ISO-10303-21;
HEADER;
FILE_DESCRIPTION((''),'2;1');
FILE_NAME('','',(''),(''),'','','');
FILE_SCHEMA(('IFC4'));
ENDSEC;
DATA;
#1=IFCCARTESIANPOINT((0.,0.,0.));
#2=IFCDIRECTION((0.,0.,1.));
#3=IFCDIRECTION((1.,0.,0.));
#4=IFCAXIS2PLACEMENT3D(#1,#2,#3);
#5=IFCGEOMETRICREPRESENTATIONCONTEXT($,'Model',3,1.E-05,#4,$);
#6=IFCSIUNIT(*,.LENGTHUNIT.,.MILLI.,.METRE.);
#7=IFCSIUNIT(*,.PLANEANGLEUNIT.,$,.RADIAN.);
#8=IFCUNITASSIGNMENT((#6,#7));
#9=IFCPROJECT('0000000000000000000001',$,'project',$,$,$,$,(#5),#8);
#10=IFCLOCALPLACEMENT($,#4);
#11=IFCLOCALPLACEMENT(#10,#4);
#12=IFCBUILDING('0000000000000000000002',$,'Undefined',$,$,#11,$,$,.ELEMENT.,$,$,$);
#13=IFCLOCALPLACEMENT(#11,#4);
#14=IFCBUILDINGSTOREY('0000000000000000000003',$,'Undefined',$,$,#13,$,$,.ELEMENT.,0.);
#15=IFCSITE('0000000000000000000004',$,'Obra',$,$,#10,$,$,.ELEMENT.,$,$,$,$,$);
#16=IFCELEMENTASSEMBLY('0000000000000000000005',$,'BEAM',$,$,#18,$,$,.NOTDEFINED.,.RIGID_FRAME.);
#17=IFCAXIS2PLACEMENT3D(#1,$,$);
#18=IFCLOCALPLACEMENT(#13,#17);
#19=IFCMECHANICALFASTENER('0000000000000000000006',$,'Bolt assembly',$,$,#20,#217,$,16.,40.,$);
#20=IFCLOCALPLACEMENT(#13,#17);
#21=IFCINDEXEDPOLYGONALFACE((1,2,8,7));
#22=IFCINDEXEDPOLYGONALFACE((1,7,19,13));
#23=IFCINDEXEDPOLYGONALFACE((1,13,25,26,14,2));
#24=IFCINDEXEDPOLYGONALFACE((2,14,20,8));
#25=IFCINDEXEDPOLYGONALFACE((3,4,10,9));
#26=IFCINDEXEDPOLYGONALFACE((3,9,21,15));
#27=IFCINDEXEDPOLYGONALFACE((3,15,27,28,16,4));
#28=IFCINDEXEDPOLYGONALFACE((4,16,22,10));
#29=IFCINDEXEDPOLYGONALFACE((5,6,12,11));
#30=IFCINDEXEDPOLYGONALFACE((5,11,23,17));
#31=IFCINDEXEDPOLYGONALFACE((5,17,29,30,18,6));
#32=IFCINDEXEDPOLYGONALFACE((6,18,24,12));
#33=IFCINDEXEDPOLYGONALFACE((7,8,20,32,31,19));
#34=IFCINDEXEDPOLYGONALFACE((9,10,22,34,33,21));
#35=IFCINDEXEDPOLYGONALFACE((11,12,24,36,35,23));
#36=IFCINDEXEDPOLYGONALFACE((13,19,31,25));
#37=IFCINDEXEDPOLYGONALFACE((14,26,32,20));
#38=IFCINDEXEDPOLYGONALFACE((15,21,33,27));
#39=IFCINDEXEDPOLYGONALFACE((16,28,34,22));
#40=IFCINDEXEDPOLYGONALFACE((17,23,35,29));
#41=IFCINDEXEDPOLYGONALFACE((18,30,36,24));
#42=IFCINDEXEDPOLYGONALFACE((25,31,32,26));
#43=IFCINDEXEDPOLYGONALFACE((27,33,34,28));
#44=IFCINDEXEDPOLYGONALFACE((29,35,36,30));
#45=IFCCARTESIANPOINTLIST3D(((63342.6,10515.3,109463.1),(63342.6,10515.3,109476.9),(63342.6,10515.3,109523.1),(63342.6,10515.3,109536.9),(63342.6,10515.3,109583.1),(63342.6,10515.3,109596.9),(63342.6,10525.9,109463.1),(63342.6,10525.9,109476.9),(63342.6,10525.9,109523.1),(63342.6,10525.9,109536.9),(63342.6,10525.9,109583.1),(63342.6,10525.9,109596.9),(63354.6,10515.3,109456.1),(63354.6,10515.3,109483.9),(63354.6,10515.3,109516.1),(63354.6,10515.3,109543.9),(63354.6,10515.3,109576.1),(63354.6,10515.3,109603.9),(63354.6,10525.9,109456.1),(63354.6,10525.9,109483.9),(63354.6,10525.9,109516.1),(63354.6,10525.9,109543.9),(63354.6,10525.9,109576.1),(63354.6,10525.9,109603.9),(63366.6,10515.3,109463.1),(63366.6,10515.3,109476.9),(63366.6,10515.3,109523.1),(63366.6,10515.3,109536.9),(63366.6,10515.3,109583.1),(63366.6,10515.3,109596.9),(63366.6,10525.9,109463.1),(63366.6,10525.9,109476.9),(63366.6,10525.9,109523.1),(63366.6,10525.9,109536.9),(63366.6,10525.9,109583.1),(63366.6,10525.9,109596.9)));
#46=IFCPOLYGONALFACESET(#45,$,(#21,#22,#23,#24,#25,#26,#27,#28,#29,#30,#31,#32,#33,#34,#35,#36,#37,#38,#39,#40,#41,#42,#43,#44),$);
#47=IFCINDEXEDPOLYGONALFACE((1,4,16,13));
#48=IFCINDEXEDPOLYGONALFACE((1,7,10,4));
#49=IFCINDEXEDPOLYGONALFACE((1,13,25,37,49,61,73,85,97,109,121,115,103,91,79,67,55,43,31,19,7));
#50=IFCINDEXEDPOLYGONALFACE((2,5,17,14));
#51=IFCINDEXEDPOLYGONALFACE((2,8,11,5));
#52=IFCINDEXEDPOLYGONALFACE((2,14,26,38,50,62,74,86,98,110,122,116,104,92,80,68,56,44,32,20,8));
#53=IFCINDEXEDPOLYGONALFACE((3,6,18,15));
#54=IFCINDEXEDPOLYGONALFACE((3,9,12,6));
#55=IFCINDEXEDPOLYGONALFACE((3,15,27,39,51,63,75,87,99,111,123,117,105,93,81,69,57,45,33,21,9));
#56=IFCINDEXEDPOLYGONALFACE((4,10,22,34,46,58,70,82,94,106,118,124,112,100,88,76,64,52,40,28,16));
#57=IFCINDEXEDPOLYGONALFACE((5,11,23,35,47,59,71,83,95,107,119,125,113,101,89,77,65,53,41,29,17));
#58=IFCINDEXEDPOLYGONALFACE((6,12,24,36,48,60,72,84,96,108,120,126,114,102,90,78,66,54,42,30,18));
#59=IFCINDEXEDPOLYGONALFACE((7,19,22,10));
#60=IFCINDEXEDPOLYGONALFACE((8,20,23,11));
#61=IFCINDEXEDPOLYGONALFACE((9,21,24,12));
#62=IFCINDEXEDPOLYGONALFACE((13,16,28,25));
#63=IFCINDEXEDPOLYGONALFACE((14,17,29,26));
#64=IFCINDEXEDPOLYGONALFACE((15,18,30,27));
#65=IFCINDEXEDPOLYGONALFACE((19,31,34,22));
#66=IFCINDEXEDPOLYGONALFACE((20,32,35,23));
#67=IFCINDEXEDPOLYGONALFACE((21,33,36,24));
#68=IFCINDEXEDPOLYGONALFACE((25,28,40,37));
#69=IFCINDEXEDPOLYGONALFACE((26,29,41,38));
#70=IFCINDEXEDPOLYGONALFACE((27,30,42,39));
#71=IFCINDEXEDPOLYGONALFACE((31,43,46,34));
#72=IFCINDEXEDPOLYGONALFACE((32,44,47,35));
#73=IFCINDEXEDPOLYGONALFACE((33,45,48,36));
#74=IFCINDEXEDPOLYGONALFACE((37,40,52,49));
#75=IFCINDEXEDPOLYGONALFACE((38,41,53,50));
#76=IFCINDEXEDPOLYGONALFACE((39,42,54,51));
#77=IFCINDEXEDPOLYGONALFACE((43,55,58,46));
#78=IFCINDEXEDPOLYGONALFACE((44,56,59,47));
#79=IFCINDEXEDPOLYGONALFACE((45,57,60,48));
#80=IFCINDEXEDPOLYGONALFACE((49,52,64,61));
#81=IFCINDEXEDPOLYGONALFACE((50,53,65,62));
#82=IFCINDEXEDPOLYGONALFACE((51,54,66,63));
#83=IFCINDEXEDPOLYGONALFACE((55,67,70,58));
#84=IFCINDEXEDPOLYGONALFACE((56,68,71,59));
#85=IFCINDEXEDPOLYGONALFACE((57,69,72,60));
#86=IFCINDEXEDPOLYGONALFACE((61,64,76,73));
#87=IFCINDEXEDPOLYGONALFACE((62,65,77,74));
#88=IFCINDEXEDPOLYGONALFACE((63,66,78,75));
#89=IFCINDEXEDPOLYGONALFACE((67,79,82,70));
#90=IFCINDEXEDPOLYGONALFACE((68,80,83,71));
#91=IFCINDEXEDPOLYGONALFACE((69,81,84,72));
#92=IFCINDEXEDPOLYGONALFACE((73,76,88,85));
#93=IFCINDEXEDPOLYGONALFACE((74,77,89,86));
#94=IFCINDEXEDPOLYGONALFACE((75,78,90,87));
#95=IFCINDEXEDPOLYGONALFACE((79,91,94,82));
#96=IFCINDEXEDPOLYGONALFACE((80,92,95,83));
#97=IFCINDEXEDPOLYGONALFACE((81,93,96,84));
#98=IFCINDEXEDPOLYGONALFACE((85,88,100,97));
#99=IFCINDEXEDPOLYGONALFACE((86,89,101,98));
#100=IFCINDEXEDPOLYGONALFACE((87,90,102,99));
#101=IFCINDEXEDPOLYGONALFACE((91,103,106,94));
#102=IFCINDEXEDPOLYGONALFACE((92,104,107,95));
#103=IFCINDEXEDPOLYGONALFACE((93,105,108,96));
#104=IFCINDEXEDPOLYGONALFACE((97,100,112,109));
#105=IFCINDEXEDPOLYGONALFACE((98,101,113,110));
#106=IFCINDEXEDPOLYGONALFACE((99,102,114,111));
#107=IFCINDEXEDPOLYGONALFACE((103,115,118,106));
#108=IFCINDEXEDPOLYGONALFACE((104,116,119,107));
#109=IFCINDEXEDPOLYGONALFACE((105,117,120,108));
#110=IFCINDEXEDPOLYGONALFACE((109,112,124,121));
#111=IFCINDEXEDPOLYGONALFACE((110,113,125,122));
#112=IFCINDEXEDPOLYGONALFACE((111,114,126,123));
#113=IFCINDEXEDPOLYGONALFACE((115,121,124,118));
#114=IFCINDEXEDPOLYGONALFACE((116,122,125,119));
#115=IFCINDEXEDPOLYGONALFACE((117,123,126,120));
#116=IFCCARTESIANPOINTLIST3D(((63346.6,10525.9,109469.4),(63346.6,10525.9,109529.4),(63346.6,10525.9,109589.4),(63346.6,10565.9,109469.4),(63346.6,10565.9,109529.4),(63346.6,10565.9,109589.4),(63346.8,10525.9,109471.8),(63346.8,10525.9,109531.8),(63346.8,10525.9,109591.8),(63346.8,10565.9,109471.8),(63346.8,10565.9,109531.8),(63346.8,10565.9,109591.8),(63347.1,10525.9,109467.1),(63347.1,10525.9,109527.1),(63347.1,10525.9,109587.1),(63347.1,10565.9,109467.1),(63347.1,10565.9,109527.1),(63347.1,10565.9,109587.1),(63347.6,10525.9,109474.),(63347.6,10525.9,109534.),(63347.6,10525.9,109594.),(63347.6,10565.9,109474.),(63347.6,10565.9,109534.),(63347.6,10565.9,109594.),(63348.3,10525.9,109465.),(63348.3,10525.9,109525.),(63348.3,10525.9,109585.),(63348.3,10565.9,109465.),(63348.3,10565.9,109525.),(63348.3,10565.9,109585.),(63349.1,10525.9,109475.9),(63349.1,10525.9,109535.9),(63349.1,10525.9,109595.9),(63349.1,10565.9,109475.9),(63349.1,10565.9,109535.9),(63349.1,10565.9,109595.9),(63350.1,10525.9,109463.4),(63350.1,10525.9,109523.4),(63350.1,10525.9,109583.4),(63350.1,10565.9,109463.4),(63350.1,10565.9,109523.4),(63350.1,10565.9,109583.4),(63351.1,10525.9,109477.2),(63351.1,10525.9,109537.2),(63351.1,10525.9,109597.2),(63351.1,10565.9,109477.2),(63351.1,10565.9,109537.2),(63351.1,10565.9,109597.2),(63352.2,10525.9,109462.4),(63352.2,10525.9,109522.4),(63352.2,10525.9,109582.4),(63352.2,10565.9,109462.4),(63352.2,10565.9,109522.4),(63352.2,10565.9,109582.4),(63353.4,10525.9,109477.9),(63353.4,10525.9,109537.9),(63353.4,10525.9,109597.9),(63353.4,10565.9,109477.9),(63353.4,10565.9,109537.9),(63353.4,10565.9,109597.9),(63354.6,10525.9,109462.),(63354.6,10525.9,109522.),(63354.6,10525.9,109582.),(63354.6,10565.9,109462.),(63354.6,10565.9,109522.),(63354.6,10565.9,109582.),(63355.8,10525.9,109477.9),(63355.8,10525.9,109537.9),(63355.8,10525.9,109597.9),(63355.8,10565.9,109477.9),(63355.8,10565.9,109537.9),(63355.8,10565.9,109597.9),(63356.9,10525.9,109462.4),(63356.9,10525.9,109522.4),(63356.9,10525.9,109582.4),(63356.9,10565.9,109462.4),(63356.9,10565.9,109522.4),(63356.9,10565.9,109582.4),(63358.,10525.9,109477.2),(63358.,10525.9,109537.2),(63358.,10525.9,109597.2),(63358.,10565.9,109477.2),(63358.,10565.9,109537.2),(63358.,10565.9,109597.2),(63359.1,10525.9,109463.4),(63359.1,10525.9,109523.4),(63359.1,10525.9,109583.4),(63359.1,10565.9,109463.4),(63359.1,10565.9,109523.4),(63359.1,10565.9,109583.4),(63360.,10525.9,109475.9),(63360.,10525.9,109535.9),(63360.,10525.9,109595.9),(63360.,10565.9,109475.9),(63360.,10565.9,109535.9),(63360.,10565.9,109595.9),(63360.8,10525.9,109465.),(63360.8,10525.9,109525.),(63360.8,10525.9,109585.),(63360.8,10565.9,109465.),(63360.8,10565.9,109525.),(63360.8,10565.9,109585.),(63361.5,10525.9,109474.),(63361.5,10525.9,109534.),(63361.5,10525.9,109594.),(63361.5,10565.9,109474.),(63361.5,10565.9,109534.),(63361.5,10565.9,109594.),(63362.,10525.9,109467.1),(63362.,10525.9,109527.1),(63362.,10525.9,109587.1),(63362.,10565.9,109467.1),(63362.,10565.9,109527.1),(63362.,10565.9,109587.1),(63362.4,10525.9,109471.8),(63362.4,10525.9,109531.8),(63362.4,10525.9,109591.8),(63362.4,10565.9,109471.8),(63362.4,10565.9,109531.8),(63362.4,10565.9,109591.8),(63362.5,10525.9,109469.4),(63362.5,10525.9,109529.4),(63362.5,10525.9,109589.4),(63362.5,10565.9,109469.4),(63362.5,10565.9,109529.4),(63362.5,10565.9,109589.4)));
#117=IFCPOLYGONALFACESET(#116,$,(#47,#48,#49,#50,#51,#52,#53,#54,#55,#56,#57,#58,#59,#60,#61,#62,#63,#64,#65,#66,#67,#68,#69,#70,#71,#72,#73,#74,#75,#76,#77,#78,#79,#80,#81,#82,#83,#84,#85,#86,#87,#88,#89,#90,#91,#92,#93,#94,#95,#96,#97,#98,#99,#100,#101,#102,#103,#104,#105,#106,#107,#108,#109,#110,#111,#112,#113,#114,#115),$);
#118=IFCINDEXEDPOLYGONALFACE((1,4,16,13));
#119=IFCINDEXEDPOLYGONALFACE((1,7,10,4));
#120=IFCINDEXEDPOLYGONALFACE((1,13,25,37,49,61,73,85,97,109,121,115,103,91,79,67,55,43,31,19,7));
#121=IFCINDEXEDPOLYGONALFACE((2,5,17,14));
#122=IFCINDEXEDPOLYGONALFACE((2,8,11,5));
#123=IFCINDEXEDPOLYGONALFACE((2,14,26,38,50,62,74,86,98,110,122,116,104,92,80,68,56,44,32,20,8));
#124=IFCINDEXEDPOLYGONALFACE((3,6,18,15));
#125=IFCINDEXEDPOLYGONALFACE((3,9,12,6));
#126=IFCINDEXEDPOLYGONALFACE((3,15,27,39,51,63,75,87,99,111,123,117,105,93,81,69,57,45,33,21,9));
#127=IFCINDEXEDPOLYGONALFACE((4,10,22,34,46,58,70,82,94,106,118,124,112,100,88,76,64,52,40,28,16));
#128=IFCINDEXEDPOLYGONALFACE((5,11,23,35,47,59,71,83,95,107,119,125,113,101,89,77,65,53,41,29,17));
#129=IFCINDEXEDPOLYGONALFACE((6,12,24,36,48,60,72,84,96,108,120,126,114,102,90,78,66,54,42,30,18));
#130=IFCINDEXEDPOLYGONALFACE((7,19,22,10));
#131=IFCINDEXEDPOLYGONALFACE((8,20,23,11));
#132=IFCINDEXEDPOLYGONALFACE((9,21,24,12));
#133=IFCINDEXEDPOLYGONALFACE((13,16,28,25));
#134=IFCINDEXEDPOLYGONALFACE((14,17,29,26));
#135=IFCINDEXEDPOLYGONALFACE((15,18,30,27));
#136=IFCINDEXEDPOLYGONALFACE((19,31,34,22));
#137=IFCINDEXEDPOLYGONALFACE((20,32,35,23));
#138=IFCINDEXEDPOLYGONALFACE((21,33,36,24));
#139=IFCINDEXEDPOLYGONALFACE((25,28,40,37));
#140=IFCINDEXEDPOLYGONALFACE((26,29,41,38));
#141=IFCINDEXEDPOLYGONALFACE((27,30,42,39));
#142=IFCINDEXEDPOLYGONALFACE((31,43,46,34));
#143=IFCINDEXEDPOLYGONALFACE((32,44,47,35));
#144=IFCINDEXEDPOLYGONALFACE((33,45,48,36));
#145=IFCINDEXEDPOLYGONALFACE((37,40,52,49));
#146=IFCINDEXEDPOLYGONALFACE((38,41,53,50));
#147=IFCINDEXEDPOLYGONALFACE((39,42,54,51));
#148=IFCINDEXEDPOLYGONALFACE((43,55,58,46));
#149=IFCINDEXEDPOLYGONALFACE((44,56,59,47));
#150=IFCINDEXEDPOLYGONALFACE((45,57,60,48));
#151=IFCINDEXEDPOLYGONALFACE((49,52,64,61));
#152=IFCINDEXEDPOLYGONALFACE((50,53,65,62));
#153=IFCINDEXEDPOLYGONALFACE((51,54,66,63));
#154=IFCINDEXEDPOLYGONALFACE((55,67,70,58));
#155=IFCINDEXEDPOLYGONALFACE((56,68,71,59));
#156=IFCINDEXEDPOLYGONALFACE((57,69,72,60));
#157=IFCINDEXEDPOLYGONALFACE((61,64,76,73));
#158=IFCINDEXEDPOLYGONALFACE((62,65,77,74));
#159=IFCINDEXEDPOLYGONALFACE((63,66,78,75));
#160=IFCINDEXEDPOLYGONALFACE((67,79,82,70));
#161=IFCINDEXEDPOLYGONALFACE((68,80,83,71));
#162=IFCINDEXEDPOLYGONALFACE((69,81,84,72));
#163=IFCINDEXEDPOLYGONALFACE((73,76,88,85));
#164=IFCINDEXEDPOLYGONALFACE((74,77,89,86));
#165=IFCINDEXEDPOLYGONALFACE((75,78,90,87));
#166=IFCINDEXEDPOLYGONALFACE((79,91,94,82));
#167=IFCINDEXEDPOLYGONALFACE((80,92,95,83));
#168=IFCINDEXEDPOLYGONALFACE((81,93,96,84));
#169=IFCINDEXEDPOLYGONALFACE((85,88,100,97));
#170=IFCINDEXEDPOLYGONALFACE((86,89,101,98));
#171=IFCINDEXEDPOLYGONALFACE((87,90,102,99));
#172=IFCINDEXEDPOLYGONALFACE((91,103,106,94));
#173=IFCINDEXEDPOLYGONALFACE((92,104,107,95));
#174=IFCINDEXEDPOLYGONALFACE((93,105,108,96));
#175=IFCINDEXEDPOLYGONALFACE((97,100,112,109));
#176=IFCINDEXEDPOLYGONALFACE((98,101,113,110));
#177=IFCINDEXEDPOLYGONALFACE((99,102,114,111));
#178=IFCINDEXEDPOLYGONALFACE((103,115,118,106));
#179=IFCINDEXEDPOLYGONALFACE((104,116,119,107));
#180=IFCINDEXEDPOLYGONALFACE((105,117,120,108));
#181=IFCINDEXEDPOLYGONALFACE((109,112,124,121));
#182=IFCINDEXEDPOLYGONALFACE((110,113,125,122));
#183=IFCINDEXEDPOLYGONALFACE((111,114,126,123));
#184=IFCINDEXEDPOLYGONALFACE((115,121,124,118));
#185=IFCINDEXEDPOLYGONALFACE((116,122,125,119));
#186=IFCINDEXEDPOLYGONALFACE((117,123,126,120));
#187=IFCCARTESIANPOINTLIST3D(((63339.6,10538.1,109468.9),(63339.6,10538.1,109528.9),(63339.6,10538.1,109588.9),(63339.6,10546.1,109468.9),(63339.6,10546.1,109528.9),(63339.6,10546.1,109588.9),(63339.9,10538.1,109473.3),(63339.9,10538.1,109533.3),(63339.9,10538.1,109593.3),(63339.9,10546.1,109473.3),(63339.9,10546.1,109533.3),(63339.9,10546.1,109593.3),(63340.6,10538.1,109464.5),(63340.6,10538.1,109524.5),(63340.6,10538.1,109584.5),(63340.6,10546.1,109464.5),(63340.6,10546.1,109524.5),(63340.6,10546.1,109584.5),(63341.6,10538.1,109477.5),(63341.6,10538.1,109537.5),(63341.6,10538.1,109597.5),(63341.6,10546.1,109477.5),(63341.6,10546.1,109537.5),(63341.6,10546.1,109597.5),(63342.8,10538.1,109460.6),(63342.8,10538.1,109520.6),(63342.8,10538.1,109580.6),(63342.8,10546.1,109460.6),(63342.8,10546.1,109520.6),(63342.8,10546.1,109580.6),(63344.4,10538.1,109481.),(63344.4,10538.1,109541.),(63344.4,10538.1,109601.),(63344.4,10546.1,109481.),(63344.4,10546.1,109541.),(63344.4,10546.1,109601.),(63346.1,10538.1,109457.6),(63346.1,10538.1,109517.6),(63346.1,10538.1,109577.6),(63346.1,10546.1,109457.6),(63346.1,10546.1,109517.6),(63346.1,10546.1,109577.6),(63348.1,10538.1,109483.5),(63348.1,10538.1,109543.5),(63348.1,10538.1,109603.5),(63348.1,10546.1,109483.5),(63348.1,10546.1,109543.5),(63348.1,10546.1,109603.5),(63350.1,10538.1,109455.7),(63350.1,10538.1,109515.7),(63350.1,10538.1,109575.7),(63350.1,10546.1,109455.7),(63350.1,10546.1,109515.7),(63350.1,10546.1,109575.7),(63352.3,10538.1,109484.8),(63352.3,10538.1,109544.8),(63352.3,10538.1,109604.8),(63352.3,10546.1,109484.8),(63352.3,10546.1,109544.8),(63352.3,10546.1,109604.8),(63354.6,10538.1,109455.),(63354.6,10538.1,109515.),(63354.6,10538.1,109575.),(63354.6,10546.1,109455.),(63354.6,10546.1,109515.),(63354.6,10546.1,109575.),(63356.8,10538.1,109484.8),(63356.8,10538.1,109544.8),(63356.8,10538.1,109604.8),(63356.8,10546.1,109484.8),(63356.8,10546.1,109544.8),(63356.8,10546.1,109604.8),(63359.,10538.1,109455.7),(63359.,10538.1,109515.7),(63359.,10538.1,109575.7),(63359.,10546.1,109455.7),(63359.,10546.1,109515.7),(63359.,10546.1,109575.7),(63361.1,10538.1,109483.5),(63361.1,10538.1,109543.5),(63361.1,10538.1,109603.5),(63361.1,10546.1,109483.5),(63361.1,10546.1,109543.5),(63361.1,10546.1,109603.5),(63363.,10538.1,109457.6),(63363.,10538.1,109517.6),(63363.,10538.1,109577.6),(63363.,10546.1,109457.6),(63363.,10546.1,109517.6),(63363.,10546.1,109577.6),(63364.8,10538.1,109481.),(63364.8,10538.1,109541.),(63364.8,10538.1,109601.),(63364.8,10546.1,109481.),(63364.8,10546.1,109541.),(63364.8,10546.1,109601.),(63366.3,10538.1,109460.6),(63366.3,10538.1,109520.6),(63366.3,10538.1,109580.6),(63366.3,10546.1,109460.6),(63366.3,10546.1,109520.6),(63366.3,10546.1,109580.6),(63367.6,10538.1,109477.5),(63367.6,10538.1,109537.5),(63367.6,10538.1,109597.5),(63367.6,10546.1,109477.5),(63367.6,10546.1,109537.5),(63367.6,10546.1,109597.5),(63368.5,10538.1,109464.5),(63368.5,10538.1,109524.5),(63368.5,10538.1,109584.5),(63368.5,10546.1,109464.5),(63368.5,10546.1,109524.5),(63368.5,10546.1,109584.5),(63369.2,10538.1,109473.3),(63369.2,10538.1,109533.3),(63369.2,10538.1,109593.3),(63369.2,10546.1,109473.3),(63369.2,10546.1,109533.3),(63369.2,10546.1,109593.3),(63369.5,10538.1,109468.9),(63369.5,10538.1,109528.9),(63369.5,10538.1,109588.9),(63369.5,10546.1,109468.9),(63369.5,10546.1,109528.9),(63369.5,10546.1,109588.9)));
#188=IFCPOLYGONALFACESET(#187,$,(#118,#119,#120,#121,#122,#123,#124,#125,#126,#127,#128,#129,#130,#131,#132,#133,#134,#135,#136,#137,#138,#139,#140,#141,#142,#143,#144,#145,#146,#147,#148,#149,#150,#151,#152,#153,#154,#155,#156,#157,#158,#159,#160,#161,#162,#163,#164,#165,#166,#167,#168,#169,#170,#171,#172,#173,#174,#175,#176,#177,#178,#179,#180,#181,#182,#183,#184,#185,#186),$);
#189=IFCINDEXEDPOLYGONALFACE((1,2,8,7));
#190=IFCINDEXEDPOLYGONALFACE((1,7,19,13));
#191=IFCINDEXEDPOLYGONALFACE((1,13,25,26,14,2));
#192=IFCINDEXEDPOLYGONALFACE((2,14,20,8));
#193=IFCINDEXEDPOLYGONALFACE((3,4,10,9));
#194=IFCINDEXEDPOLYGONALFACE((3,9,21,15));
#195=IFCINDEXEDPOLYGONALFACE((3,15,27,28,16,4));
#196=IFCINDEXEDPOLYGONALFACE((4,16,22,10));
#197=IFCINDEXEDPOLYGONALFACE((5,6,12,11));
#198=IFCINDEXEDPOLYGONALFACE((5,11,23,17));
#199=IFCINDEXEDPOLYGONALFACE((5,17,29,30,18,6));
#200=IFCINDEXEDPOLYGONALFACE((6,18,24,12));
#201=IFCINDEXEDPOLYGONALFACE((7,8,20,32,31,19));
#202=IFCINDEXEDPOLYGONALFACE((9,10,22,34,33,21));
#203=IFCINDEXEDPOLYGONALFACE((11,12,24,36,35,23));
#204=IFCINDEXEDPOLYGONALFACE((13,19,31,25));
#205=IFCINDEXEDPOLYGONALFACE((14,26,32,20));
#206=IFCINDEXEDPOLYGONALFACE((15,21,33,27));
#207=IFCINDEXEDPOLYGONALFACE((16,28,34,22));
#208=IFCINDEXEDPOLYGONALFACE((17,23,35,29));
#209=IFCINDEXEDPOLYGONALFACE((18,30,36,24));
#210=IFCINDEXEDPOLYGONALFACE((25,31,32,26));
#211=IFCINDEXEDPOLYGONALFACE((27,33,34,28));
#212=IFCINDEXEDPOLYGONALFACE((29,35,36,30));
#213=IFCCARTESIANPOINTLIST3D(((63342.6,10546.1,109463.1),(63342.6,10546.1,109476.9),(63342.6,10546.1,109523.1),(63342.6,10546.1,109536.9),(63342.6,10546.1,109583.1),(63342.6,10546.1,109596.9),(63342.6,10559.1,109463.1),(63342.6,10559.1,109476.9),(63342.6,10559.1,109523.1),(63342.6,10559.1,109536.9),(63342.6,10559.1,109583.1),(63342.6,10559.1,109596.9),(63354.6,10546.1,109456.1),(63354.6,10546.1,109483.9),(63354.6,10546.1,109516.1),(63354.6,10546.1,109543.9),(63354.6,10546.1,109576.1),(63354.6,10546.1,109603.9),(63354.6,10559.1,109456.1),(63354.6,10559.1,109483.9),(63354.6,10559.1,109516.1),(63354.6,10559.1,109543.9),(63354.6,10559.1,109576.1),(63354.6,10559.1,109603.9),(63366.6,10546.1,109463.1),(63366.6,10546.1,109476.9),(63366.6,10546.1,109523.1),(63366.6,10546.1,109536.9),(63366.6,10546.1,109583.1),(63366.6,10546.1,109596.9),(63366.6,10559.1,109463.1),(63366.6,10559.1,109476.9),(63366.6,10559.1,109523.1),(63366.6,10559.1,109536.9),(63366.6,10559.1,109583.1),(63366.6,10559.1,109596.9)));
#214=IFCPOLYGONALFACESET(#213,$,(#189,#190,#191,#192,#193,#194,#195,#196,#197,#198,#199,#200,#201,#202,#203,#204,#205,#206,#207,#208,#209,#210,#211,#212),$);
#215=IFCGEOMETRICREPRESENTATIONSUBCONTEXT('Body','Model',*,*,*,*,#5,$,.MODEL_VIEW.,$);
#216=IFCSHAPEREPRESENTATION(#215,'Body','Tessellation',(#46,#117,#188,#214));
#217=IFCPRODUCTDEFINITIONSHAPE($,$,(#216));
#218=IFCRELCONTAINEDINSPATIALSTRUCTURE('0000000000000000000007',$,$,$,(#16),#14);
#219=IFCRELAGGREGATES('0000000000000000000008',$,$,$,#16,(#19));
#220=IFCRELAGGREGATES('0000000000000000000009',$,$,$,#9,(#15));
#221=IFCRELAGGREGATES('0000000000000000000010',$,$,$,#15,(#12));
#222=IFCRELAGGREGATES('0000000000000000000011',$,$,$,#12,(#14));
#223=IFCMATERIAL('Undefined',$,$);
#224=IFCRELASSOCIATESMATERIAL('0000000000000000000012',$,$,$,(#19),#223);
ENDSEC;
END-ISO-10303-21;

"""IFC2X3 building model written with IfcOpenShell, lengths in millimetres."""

from ifc_helpers import new_model, si_unit, frame, origin_with_axes, origin_2d_with_axis, place, context, subcontext, project, spatial, polyline, circle, outline, extrude, source, transform, mapped, material, element, aggregate, save


model = new_model("IFC2X3")

# Units and contexts
model_context = context("Model", 3, precision=1e-05, world=origin_with_axes())
body_context = subcontext(model_context, "Body", "Model", "MODEL_VIEW")
ifc_project = project(units=[si_unit("LENGTHUNIT", "METRE", prefix="MILLI"), si_unit("PLANEANGLEUNIT", "RADIAN")], contexts=[model_context])

# Site, building, storey
site_placement = place(None, origin_with_axes())
site = spatial("IfcSite", under=ifc_project, at=site_placement, Name="Obra", CompositionType="ELEMENT")
building_placement = place(site_placement, origin_with_axes())
building = spatial("IfcBuilding", under=site, at=building_placement, Name="Undefined", CompositionType="ELEMENT")
storey_placement = place(building_placement, origin_with_axes())
storey = spatial("IfcBuildingStorey", under=building, at=storey_placement, Name="Undefined", CompositionType="ELEMENT", Elevation=0.0)

# Element assembly
assembly_1_placement = place(storey_placement, origin_with_axes())
assembly_1 = element("IfcElementAssembly", 1, at=assembly_1_placement, inside=storey, Name="BEAM", AssemblyPlace="NOTDEFINED", PredefinedType="RIGID_FRAME")

# Mechanical fastener
ifc_material_1 = material(Name="Undefined")
shared_shape_1 = source(origin_with_axes(), body_context, "Body", "SweptSolid", [
    extrude(outline(polyline([(13.9, 0.0), (6.9, 12.0), (-6.9, 12.0), (-13.9, 0.0), (-6.9, -12.0), (6.9, -12.0), (13.9, 0.0)])), frame((0.0, -19.7, 0.0), z_axis=(0.0, 1.0, 0.0), x_axis=(1.0, 0.0, 0.0)), (0.0, 0.0, 1.0), 10.6),
    extrude(circle(Radius=8.0, at=origin_2d_with_axis()), frame((0.0, -9.1, 0.0), z_axis=(0.0, 1.0, 0.0), x_axis=(1.0, 0.0, 0.0)), (0.0, 0.0, 1.0), 40.0),
    extrude(circle(Radius=15.0, at=origin_2d_with_axis()), frame((0.0, 3.1, 0.0), z_axis=(0.0, 1.0, 0.0), x_axis=(1.0, 0.0, 0.0)), (0.0, 0.0, 1.0), 8.0),
    extrude(outline(polyline([(13.9, 0.0), (6.9, 12.0), (-6.9, 12.0), (-13.9, 0.0), (-6.9, -12.0), (6.9, -12.0), (13.9, 0.0)])), frame((0.0, 11.1, 0.0), z_axis=(0.0, 1.0, 0.0), x_axis=(1.0, 0.0, 0.0)), (0.0, 0.0, 1.0), 13.0),
])
mechanical_fastener_1_placement = place(assembly_1_placement, frame((63304.6, 10535.0, 109650.0), z_axis=(1.0, -0.000126, 0.0), x_axis=(0.0, 0.0, -1.0)))
mechanical_fastener_1 = element("IfcMechanicalFastener", 2, at=mechanical_fastener_1_placement, material=ifc_material_1, Name="Bolt assembly", NominalDiameter=16.0, NominalLength=40.0, context=body_context, shape_type="MappedRepresentation", body=[
    mapped(shared_shape_1, transform((60.0, 0.0, 50.0))),
    mapped(shared_shape_1, transform((120.0, 0.0, 50.0))),
    mapped(shared_shape_1, transform((180.0, 0.0, 50.0))),
])
aggregate(assembly_1, [mechanical_fastener_1])

save(model, "model.ifc")
